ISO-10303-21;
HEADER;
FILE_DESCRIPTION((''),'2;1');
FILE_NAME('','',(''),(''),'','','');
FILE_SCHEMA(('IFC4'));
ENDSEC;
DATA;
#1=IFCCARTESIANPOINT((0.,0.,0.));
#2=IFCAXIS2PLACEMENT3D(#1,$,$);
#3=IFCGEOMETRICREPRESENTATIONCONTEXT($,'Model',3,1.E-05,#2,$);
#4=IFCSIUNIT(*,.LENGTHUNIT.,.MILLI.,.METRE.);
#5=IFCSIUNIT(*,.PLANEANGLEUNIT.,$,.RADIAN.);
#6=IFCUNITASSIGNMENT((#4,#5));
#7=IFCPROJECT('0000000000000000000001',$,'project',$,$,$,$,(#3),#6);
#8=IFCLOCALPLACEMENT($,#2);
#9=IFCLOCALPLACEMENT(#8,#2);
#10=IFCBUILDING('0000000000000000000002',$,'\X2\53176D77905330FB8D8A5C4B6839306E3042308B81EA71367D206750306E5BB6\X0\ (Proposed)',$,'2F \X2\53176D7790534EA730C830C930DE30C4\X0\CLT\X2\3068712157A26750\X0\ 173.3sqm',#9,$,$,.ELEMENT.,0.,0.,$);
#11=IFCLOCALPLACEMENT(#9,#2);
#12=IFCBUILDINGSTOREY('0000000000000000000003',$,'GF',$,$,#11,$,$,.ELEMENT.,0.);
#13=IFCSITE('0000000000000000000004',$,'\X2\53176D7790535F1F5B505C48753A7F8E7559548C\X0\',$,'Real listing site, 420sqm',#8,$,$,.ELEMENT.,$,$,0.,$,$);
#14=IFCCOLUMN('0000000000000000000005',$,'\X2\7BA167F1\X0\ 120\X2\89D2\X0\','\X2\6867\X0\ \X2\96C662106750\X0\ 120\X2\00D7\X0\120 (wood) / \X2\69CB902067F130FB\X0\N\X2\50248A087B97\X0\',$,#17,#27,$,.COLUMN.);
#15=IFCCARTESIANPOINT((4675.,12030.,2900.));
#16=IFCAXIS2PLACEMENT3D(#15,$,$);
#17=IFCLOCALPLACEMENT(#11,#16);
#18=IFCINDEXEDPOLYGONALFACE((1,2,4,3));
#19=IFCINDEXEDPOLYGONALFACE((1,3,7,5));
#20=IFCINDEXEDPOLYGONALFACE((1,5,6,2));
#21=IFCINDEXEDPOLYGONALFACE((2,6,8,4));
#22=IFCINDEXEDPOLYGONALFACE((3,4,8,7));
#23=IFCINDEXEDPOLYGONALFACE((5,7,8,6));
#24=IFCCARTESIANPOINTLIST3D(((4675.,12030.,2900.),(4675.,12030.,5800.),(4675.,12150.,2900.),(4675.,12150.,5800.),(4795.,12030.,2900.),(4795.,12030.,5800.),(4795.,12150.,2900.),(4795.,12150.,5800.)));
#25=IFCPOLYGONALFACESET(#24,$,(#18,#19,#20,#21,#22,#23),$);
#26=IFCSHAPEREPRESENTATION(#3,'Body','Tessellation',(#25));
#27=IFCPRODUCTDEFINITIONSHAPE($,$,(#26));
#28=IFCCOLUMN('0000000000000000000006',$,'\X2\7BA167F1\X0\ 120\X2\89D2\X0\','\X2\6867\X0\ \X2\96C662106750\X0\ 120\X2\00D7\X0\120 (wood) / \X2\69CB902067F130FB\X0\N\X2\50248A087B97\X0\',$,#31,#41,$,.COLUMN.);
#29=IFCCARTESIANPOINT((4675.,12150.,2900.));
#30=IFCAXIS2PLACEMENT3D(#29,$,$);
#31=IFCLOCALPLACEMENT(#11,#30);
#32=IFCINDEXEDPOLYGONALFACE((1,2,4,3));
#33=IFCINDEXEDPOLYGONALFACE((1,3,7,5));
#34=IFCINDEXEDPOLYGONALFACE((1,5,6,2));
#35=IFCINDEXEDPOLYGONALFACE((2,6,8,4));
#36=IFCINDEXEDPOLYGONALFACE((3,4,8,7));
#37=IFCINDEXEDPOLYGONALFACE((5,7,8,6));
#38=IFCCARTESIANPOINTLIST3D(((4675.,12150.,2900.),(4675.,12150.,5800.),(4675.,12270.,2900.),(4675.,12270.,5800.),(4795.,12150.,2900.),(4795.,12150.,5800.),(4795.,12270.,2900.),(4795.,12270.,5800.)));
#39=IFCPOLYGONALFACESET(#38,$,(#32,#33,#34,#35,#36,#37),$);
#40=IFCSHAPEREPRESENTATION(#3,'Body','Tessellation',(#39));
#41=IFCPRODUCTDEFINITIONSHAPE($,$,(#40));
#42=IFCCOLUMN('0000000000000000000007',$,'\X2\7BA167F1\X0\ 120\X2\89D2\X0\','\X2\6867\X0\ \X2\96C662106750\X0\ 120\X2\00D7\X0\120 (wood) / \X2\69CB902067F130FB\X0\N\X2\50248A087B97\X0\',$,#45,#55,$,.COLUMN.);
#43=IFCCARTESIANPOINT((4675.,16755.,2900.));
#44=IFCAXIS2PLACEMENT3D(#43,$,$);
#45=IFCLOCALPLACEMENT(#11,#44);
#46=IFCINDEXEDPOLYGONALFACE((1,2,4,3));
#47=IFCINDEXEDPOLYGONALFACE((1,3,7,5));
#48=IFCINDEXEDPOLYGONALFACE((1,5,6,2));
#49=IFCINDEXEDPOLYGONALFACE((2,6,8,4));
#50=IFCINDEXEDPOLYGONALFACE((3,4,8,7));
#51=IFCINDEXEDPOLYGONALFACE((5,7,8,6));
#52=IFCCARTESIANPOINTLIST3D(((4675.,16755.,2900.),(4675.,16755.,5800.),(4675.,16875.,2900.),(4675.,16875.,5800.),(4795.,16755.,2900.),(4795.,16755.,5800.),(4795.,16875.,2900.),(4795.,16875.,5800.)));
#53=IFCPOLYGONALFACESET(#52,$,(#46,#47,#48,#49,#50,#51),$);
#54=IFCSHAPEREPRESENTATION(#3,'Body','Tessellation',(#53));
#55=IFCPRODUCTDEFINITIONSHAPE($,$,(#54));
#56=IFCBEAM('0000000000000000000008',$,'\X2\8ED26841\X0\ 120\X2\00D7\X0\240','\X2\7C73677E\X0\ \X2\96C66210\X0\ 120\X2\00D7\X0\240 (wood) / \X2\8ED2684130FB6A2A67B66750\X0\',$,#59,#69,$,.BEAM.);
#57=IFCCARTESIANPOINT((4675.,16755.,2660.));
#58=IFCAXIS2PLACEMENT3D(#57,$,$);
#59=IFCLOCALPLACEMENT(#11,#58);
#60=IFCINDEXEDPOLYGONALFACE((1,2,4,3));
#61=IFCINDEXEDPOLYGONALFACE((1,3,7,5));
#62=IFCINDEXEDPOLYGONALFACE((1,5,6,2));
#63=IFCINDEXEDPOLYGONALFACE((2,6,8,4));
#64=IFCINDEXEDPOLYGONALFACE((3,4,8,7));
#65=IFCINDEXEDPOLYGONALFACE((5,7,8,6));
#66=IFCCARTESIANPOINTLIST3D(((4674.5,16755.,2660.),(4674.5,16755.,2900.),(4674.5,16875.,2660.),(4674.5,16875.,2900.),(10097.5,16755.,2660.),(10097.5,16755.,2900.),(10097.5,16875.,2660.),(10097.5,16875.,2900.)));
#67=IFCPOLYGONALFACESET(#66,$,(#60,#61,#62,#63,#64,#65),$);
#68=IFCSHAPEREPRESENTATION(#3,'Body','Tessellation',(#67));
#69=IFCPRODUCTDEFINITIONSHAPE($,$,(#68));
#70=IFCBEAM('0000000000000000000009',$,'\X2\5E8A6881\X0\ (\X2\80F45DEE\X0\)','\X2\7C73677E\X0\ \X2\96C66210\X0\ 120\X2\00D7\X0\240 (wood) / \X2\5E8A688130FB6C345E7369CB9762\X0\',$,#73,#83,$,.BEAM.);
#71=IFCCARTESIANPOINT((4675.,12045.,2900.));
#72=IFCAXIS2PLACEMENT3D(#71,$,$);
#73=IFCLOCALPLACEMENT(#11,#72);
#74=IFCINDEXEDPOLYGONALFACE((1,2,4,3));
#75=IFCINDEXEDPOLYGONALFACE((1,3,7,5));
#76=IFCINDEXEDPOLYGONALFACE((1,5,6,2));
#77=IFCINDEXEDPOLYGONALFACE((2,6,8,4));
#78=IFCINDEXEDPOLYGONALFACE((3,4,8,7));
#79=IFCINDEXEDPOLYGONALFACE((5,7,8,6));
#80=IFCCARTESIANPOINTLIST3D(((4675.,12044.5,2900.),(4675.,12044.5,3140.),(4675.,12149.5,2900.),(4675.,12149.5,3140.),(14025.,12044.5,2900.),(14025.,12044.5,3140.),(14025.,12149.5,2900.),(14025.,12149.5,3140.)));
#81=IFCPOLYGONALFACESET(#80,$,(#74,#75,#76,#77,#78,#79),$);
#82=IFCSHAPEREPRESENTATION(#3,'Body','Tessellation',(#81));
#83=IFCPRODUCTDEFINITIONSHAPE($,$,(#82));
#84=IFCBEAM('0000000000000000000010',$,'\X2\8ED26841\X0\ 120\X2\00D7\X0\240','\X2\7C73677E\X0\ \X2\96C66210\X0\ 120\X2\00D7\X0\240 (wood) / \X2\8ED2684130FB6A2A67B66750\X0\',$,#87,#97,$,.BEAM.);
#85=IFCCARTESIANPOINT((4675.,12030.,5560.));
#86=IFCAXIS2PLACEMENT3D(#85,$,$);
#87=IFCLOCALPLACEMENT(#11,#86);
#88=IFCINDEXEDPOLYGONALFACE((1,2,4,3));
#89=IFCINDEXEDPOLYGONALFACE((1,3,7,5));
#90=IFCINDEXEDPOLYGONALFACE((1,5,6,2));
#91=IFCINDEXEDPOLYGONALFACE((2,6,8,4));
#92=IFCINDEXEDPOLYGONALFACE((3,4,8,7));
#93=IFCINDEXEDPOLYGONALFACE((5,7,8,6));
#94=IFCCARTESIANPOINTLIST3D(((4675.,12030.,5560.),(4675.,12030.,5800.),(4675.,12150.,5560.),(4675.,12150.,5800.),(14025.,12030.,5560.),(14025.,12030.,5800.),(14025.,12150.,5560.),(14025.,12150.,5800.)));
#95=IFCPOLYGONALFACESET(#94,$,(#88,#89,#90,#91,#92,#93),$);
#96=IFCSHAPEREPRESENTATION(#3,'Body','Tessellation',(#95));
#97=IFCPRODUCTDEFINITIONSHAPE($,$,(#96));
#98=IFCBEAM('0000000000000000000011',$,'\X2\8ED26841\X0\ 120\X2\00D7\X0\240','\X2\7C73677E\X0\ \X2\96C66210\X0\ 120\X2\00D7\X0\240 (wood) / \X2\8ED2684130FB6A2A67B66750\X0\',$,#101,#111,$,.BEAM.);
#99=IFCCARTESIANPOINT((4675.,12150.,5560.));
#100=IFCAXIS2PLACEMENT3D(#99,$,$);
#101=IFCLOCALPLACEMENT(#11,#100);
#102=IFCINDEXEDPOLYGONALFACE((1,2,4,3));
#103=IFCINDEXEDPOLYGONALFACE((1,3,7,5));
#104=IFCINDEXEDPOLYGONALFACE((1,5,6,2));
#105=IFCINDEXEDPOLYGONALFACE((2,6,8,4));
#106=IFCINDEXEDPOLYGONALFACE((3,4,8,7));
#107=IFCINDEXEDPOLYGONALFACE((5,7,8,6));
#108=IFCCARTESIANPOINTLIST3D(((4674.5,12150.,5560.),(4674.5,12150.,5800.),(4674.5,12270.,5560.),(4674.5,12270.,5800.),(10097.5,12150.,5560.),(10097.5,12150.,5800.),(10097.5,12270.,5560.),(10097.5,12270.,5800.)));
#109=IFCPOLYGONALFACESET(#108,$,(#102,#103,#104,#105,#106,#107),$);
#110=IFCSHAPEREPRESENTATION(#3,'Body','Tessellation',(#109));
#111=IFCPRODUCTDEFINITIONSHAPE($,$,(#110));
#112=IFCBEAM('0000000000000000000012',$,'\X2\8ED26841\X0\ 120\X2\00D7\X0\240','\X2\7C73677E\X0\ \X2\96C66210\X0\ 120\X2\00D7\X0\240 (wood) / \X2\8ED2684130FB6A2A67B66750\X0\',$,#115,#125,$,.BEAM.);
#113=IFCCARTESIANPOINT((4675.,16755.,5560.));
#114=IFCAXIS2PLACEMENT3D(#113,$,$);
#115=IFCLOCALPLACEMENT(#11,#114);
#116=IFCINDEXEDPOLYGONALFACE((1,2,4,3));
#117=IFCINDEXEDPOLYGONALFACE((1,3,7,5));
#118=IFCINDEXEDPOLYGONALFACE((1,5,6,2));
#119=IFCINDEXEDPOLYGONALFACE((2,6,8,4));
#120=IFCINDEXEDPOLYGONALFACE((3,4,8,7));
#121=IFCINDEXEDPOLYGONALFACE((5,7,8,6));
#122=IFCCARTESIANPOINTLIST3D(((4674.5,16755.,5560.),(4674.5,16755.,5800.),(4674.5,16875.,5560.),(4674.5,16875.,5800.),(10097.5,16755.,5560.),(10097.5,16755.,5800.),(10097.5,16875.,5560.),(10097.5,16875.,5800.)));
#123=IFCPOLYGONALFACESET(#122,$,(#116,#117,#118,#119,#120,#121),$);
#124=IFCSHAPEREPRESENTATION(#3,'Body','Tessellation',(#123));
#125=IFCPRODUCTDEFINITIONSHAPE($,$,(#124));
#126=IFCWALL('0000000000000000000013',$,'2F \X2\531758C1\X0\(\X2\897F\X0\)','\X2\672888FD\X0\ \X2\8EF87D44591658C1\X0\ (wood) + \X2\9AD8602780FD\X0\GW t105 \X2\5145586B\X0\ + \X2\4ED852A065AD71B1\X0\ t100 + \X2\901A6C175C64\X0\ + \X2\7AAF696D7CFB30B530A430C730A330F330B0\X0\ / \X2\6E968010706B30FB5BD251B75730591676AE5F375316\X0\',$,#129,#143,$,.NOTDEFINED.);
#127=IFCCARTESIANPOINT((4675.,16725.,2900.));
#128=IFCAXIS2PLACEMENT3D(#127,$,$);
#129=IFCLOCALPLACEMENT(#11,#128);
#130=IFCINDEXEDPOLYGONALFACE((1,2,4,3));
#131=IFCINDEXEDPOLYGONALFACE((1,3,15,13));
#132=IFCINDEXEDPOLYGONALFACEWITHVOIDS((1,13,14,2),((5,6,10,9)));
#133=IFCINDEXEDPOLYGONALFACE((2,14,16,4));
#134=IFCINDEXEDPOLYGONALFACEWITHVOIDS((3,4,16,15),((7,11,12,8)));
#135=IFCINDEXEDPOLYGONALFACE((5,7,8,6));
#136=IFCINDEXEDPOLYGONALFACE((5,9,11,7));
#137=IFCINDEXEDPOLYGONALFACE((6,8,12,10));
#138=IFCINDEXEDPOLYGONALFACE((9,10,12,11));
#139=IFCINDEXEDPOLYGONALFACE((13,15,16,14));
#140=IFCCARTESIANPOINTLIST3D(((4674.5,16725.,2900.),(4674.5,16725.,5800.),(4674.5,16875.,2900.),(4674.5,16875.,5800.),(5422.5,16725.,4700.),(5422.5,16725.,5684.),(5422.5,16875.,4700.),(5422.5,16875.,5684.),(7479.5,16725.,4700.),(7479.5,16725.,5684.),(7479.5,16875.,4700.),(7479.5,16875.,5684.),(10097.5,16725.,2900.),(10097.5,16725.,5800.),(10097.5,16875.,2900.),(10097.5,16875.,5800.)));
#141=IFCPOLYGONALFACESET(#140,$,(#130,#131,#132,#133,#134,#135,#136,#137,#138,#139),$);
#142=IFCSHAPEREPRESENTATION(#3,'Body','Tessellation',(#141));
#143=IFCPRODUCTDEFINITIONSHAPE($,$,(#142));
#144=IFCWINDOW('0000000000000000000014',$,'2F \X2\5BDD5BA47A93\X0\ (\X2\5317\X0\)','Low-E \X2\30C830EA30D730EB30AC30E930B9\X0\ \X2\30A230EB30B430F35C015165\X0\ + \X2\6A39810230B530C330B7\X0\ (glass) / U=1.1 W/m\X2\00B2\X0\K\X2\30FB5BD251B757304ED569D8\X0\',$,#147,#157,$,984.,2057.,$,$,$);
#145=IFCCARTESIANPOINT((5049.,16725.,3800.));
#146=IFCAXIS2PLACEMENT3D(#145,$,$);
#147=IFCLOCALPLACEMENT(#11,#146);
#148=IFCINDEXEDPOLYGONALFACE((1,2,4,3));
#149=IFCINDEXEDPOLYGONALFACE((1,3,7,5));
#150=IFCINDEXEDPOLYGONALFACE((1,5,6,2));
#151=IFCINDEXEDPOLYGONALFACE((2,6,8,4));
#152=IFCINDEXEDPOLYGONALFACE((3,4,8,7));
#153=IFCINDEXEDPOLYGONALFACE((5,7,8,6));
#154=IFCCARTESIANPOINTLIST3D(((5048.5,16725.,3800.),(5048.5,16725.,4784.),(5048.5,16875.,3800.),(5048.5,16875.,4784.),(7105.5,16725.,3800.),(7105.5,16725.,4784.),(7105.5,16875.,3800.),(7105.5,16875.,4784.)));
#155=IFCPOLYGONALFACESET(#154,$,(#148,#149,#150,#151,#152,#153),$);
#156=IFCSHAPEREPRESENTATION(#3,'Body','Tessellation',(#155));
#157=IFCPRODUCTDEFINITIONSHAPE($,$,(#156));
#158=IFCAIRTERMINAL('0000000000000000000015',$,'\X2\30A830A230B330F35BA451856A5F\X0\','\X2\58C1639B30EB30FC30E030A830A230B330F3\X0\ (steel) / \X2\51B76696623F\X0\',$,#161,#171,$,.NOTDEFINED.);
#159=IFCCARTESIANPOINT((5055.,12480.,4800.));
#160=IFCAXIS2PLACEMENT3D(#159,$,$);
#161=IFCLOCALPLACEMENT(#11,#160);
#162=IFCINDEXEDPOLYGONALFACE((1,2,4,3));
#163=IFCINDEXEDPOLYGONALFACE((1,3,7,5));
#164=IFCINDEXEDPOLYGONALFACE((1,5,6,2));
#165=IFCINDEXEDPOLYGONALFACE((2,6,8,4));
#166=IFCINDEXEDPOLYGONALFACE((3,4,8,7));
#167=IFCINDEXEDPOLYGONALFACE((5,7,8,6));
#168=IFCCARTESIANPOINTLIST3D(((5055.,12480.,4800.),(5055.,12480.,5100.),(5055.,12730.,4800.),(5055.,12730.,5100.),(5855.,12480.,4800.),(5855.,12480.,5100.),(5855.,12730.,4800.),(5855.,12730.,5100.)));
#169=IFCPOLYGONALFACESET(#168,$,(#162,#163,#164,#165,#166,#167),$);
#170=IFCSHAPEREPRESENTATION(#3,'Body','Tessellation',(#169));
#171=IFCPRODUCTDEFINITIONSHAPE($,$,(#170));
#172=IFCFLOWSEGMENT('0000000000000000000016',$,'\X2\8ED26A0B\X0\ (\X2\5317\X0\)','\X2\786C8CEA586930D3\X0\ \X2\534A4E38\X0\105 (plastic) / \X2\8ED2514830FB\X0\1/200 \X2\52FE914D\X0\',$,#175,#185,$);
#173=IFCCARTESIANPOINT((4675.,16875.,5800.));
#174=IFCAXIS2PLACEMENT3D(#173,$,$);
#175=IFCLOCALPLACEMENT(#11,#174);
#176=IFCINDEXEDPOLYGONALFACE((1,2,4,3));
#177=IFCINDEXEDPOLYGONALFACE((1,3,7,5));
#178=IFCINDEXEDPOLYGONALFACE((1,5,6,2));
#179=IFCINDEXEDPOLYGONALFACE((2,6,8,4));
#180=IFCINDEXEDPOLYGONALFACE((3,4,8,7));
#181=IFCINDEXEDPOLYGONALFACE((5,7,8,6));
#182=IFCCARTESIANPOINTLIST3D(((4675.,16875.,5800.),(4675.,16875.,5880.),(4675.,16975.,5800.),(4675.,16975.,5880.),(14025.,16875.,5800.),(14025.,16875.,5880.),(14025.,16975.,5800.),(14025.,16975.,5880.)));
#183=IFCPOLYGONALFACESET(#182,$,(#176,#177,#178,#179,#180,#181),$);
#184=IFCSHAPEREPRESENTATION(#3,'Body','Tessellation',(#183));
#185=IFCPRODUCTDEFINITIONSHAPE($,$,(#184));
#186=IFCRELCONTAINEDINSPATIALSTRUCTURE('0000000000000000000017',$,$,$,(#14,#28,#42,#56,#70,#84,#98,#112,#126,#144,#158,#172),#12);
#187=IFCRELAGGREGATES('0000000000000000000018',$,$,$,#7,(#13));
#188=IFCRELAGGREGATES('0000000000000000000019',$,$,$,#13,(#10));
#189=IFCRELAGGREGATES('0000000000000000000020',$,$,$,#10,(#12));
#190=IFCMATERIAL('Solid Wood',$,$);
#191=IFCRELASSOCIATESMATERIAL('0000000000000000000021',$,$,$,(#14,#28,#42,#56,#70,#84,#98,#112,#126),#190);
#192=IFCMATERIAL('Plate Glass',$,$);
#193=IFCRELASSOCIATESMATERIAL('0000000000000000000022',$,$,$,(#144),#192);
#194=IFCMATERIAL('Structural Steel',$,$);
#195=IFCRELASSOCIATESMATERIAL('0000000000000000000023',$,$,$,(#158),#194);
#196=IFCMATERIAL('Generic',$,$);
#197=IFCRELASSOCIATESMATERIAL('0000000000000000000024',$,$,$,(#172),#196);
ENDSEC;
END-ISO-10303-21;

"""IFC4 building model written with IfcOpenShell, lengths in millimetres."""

from ifc_helpers import new_model, si_unit, frame, frame_2d, origin, place, context, project, spatial, rectangle, extrude, material, element, fill, save


model = new_model("IFC4")

# Units and contexts
model_context = context("Model", 3, precision=1e-05, world=origin())
ifc_project = project(units=[si_unit("LENGTHUNIT", "METRE", prefix="MILLI"), si_unit("PLANEANGLEUNIT", "RADIAN")], contexts=[model_context])

# Site, building, storey
site_placement = place(None, origin())
site = spatial("IfcSite", under=ifc_project, at=site_placement, Name="北海道弟子屈町美留和", ObjectType="Real listing site, 420sqm", CompositionType="ELEMENT", RefElevation=0.0)
building_placement = place(site_placement, origin())
building = spatial("IfcBuilding", under=site, at=building_placement, Name="北海道・越屋根のある自然素材の家 (Proposed)", ObjectType="2F 北海道产トドマツCLTと無垢材 173.3sqm", CompositionType="ELEMENT", ElevationOfRefHeight=0.0, ElevationOfTerrain=0.0)
storey_placement = place(building_placement, origin())
storey = spatial("IfcBuildingStorey", under=building, at=storey_placement, Name="GF", CompositionType="ELEMENT", Elevation=0.0)

# Columns
ifc_material_1 = material(Name="Solid Wood")
column_1_placement = place(storey_placement, frame((4675.0, 12030.0, 2900.0)))
element("IfcColumn", 1, at=column_1_placement, inside=storey, material=ifc_material_1, Name="管柱 120角", Description="桧 集成材 120×120 (wood) / 構造柱・N値計算", PredefinedType="COLUMN", context=model_context, shape_type="SweptSolid", body=[
    extrude(rectangle(XDim=120.0, YDim=120.0, at=frame_2d((60.0, 60.0))), frame((4675.0, 12030.0, 2900.0)), (0.0, 0.0, 1.0), 2900.0),
])
column_2_placement = place(storey_placement, frame((4675.0, 12150.0, 2900.0)))
element("IfcColumn", 2, at=column_2_placement, inside=storey, material=ifc_material_1, Name="管柱 120角", Description="桧 集成材 120×120 (wood) / 構造柱・N値計算", PredefinedType="COLUMN", context=model_context, shape_type="SweptSolid", body=[
    extrude(rectangle(XDim=120.0, YDim=120.0, at=frame_2d((60.0, 60.0))), frame((4675.0, 12150.0, 2900.0)), (0.0, 0.0, 1.0), 2900.0),
])
column_3_placement = place(storey_placement, frame((4675.0, 16755.0, 2900.0)))
element("IfcColumn", 3, at=column_3_placement, inside=storey, material=ifc_material_1, Name="管柱 120角", Description="桧 集成材 120×120 (wood) / 構造柱・N値計算", PredefinedType="COLUMN", context=model_context, shape_type="SweptSolid", body=[
    extrude(rectangle(XDim=120.0, YDim=120.0, at=frame_2d((60.0, 60.0))), frame((4675.0, 16755.0, 2900.0)), (0.0, 0.0, 1.0), 2900.0),
])

# Beams
beam_1_placement = place(storey_placement, frame((4675.0, 16755.0, 2660.0)))
element("IfcBeam", 4, at=beam_1_placement, inside=storey, material=ifc_material_1, Name="軒桁 120×240", Description="米松 集成 120×240 (wood) / 軒桁・横架材", PredefinedType="BEAM", context=model_context, shape_type="SweptSolid", body=[
    extrude(rectangle(XDim=5423.0, YDim=120.0, at=frame_2d((2711.0, 60.0))), frame((4675.0, 16755.0, 2660.0)), (0.0, 0.0, 1.0), 240.0),
])
beam_2_placement = place(storey_placement, frame((4675.0, 12045.0, 2900.0)))
element("IfcBeam", 5, at=beam_2_placement, inside=storey, material=ifc_material_1, Name="床梁 (胴差)", Description="米松 集成 120×240 (wood) / 床梁・水平構面", PredefinedType="BEAM", context=model_context, shape_type="SweptSolid", body=[
    extrude(rectangle(XDim=9350.0, YDim=105.0, at=frame_2d((4675.0, 52.0))), frame((4675.0, 12045.0, 2900.0)), (0.0, 0.0, 1.0), 240.0),
])
beam_3_placement = place(storey_placement, frame((4675.0, 12030.0, 5560.0)))
element("IfcBeam", 6, at=beam_3_placement, inside=storey, material=ifc_material_1, Name="軒桁 120×240", Description="米松 集成 120×240 (wood) / 軒桁・横架材", PredefinedType="BEAM", context=model_context, shape_type="SweptSolid", body=[
    extrude(rectangle(XDim=9350.0, YDim=120.0, at=frame_2d((4675.0, 60.0))), frame((4675.0, 12030.0, 5560.0)), (0.0, 0.0, 1.0), 240.0),
])
beam_4_placement = place(storey_placement, frame((4675.0, 12150.0, 5560.0)))
element("IfcBeam", 7, at=beam_4_placement, inside=storey, material=ifc_material_1, Name="軒桁 120×240", Description="米松 集成 120×240 (wood) / 軒桁・横架材", PredefinedType="BEAM", context=model_context, shape_type="SweptSolid", body=[
    extrude(rectangle(XDim=5423.0, YDim=120.0, at=frame_2d((2711.0, 60.0))), frame((4675.0, 12150.0, 5560.0)), (0.0, 0.0, 1.0), 240.0),
])
beam_5_placement = place(storey_placement, frame((4675.0, 16755.0, 5560.0)))
element("IfcBeam", 8, at=beam_5_placement, inside=storey, material=ifc_material_1, Name="軒桁 120×240", Description="米松 集成 120×240 (wood) / 軒桁・横架材", PredefinedType="BEAM", context=model_context, shape_type="SweptSolid", body=[
    extrude(rectangle(XDim=5423.0, YDim=120.0, at=frame_2d((2711.0, 60.0))), frame((4675.0, 16755.0, 5560.0)), (0.0, 0.0, 1.0), 240.0),
])

# Wall, opening, window
wall_1_placement = place(storey_placement, frame((4675.0, 16725.0, 2900.0)))
wall_1 = element("IfcWall", 9, at=wall_1_placement, inside=storey, material=ifc_material_1, Name="2F 北壁(西)", Description="木製 軸組外壁 (wood) + 高性能GW t105 充填 + 付加断熱 t100 + 通気層 + 窯業系サイディング / 準耐火・寒冷地外皮強化", PredefinedType="NOTDEFINED", context=model_context, shape_type="SweptSolid", body=[
    extrude(rectangle(XDim=5423.0, YDim=150.0, at=frame_2d((2711.0, 75.0))), frame((4675.0, 16725.0, 2900.0)), (0.0, 0.0, 1.0), 2900.0),
])
opening_placement = place(storey_placement, frame((5049.0, 16725.0, 3800.0)))
opening = element("IfcOpeningElement", 10, at=opening_placement, cuts=wall_1, PredefinedType="NOTDEFINED", context=model_context, shape_type="SweptSolid", body=[
    extrude(rectangle(XDim=2057.0, YDim=150.0, at=frame_2d((1028.0, 75.0))), frame((5049.0, 16725.0, 3800.0)), (0.0, 0.0, 1.0), 984.0),
])
ifc_material_2 = material(Name="Plate Glass")
window_placement = place(storey_placement, frame((5049.0, 16725.0, 3800.0)))
window = element("IfcWindow", 11, at=window_placement, inside=storey, material=ifc_material_2, Name="2F 寝室窓 (北)", Description="Low-E トリプルガラス アルゴン封入 + 樹脂サッシ (glass) / U=1.1 W/m²K・寒冷地仕様", OverallHeight=984.0, OverallWidth=2057.0, context=model_context, shape_type="SweptSolid", body=[
    extrude(rectangle(XDim=2057.0, YDim=150.0, at=frame_2d((1028.0, 75.0))), frame((5049.0, 16725.0, 3800.0)), (0.0, 0.0, 1.0), 984.0),
])
fill(opening, window)

# Shared definitions
ifc_material_3 = material(Name="Structural Steel")

# Shared definitions
ifc_material_4 = material(Name="Generic")

# Air terminal
air_terminal_placement = place(storey_placement, frame((5055.0, 12480.0, 4800.0)))
element("IfcAirTerminal", 12, at=air_terminal_placement, inside=storey, material=ifc_material_3, Name="エアコン室内機", Description="壁掛ルームエアコン (steel) / 冷暖房", PredefinedType="NOTDEFINED", context=model_context, shape_type="SweptSolid", body=[
    extrude(rectangle(XDim=800.0, YDim=250.0, at=frame_2d((400.0, 125.0))), frame((5055.0, 12480.0, 4800.0)), (0.0, 0.0, 1.0), 300.0),
])

# Flow segment
flow_segment_placement = place(storey_placement, frame((4675.0, 16875.0, 5800.0)))
element("IfcFlowSegment", 13, at=flow_segment_placement, inside=storey, material=ifc_material_4, Name="軒樋 (北)", Description="硬質塩ビ 半丸105 (plastic) / 軒先・1/200 勾配", context=model_context, shape_type="SweptSolid", body=[
    extrude(rectangle(XDim=9350.0, YDim=100.0, at=frame_2d((4675.0, 50.0))), frame((4675.0, 16875.0, 5800.0)), (0.0, 0.0, 1.0), 80.0),
])

save(model, "model.ifc")
